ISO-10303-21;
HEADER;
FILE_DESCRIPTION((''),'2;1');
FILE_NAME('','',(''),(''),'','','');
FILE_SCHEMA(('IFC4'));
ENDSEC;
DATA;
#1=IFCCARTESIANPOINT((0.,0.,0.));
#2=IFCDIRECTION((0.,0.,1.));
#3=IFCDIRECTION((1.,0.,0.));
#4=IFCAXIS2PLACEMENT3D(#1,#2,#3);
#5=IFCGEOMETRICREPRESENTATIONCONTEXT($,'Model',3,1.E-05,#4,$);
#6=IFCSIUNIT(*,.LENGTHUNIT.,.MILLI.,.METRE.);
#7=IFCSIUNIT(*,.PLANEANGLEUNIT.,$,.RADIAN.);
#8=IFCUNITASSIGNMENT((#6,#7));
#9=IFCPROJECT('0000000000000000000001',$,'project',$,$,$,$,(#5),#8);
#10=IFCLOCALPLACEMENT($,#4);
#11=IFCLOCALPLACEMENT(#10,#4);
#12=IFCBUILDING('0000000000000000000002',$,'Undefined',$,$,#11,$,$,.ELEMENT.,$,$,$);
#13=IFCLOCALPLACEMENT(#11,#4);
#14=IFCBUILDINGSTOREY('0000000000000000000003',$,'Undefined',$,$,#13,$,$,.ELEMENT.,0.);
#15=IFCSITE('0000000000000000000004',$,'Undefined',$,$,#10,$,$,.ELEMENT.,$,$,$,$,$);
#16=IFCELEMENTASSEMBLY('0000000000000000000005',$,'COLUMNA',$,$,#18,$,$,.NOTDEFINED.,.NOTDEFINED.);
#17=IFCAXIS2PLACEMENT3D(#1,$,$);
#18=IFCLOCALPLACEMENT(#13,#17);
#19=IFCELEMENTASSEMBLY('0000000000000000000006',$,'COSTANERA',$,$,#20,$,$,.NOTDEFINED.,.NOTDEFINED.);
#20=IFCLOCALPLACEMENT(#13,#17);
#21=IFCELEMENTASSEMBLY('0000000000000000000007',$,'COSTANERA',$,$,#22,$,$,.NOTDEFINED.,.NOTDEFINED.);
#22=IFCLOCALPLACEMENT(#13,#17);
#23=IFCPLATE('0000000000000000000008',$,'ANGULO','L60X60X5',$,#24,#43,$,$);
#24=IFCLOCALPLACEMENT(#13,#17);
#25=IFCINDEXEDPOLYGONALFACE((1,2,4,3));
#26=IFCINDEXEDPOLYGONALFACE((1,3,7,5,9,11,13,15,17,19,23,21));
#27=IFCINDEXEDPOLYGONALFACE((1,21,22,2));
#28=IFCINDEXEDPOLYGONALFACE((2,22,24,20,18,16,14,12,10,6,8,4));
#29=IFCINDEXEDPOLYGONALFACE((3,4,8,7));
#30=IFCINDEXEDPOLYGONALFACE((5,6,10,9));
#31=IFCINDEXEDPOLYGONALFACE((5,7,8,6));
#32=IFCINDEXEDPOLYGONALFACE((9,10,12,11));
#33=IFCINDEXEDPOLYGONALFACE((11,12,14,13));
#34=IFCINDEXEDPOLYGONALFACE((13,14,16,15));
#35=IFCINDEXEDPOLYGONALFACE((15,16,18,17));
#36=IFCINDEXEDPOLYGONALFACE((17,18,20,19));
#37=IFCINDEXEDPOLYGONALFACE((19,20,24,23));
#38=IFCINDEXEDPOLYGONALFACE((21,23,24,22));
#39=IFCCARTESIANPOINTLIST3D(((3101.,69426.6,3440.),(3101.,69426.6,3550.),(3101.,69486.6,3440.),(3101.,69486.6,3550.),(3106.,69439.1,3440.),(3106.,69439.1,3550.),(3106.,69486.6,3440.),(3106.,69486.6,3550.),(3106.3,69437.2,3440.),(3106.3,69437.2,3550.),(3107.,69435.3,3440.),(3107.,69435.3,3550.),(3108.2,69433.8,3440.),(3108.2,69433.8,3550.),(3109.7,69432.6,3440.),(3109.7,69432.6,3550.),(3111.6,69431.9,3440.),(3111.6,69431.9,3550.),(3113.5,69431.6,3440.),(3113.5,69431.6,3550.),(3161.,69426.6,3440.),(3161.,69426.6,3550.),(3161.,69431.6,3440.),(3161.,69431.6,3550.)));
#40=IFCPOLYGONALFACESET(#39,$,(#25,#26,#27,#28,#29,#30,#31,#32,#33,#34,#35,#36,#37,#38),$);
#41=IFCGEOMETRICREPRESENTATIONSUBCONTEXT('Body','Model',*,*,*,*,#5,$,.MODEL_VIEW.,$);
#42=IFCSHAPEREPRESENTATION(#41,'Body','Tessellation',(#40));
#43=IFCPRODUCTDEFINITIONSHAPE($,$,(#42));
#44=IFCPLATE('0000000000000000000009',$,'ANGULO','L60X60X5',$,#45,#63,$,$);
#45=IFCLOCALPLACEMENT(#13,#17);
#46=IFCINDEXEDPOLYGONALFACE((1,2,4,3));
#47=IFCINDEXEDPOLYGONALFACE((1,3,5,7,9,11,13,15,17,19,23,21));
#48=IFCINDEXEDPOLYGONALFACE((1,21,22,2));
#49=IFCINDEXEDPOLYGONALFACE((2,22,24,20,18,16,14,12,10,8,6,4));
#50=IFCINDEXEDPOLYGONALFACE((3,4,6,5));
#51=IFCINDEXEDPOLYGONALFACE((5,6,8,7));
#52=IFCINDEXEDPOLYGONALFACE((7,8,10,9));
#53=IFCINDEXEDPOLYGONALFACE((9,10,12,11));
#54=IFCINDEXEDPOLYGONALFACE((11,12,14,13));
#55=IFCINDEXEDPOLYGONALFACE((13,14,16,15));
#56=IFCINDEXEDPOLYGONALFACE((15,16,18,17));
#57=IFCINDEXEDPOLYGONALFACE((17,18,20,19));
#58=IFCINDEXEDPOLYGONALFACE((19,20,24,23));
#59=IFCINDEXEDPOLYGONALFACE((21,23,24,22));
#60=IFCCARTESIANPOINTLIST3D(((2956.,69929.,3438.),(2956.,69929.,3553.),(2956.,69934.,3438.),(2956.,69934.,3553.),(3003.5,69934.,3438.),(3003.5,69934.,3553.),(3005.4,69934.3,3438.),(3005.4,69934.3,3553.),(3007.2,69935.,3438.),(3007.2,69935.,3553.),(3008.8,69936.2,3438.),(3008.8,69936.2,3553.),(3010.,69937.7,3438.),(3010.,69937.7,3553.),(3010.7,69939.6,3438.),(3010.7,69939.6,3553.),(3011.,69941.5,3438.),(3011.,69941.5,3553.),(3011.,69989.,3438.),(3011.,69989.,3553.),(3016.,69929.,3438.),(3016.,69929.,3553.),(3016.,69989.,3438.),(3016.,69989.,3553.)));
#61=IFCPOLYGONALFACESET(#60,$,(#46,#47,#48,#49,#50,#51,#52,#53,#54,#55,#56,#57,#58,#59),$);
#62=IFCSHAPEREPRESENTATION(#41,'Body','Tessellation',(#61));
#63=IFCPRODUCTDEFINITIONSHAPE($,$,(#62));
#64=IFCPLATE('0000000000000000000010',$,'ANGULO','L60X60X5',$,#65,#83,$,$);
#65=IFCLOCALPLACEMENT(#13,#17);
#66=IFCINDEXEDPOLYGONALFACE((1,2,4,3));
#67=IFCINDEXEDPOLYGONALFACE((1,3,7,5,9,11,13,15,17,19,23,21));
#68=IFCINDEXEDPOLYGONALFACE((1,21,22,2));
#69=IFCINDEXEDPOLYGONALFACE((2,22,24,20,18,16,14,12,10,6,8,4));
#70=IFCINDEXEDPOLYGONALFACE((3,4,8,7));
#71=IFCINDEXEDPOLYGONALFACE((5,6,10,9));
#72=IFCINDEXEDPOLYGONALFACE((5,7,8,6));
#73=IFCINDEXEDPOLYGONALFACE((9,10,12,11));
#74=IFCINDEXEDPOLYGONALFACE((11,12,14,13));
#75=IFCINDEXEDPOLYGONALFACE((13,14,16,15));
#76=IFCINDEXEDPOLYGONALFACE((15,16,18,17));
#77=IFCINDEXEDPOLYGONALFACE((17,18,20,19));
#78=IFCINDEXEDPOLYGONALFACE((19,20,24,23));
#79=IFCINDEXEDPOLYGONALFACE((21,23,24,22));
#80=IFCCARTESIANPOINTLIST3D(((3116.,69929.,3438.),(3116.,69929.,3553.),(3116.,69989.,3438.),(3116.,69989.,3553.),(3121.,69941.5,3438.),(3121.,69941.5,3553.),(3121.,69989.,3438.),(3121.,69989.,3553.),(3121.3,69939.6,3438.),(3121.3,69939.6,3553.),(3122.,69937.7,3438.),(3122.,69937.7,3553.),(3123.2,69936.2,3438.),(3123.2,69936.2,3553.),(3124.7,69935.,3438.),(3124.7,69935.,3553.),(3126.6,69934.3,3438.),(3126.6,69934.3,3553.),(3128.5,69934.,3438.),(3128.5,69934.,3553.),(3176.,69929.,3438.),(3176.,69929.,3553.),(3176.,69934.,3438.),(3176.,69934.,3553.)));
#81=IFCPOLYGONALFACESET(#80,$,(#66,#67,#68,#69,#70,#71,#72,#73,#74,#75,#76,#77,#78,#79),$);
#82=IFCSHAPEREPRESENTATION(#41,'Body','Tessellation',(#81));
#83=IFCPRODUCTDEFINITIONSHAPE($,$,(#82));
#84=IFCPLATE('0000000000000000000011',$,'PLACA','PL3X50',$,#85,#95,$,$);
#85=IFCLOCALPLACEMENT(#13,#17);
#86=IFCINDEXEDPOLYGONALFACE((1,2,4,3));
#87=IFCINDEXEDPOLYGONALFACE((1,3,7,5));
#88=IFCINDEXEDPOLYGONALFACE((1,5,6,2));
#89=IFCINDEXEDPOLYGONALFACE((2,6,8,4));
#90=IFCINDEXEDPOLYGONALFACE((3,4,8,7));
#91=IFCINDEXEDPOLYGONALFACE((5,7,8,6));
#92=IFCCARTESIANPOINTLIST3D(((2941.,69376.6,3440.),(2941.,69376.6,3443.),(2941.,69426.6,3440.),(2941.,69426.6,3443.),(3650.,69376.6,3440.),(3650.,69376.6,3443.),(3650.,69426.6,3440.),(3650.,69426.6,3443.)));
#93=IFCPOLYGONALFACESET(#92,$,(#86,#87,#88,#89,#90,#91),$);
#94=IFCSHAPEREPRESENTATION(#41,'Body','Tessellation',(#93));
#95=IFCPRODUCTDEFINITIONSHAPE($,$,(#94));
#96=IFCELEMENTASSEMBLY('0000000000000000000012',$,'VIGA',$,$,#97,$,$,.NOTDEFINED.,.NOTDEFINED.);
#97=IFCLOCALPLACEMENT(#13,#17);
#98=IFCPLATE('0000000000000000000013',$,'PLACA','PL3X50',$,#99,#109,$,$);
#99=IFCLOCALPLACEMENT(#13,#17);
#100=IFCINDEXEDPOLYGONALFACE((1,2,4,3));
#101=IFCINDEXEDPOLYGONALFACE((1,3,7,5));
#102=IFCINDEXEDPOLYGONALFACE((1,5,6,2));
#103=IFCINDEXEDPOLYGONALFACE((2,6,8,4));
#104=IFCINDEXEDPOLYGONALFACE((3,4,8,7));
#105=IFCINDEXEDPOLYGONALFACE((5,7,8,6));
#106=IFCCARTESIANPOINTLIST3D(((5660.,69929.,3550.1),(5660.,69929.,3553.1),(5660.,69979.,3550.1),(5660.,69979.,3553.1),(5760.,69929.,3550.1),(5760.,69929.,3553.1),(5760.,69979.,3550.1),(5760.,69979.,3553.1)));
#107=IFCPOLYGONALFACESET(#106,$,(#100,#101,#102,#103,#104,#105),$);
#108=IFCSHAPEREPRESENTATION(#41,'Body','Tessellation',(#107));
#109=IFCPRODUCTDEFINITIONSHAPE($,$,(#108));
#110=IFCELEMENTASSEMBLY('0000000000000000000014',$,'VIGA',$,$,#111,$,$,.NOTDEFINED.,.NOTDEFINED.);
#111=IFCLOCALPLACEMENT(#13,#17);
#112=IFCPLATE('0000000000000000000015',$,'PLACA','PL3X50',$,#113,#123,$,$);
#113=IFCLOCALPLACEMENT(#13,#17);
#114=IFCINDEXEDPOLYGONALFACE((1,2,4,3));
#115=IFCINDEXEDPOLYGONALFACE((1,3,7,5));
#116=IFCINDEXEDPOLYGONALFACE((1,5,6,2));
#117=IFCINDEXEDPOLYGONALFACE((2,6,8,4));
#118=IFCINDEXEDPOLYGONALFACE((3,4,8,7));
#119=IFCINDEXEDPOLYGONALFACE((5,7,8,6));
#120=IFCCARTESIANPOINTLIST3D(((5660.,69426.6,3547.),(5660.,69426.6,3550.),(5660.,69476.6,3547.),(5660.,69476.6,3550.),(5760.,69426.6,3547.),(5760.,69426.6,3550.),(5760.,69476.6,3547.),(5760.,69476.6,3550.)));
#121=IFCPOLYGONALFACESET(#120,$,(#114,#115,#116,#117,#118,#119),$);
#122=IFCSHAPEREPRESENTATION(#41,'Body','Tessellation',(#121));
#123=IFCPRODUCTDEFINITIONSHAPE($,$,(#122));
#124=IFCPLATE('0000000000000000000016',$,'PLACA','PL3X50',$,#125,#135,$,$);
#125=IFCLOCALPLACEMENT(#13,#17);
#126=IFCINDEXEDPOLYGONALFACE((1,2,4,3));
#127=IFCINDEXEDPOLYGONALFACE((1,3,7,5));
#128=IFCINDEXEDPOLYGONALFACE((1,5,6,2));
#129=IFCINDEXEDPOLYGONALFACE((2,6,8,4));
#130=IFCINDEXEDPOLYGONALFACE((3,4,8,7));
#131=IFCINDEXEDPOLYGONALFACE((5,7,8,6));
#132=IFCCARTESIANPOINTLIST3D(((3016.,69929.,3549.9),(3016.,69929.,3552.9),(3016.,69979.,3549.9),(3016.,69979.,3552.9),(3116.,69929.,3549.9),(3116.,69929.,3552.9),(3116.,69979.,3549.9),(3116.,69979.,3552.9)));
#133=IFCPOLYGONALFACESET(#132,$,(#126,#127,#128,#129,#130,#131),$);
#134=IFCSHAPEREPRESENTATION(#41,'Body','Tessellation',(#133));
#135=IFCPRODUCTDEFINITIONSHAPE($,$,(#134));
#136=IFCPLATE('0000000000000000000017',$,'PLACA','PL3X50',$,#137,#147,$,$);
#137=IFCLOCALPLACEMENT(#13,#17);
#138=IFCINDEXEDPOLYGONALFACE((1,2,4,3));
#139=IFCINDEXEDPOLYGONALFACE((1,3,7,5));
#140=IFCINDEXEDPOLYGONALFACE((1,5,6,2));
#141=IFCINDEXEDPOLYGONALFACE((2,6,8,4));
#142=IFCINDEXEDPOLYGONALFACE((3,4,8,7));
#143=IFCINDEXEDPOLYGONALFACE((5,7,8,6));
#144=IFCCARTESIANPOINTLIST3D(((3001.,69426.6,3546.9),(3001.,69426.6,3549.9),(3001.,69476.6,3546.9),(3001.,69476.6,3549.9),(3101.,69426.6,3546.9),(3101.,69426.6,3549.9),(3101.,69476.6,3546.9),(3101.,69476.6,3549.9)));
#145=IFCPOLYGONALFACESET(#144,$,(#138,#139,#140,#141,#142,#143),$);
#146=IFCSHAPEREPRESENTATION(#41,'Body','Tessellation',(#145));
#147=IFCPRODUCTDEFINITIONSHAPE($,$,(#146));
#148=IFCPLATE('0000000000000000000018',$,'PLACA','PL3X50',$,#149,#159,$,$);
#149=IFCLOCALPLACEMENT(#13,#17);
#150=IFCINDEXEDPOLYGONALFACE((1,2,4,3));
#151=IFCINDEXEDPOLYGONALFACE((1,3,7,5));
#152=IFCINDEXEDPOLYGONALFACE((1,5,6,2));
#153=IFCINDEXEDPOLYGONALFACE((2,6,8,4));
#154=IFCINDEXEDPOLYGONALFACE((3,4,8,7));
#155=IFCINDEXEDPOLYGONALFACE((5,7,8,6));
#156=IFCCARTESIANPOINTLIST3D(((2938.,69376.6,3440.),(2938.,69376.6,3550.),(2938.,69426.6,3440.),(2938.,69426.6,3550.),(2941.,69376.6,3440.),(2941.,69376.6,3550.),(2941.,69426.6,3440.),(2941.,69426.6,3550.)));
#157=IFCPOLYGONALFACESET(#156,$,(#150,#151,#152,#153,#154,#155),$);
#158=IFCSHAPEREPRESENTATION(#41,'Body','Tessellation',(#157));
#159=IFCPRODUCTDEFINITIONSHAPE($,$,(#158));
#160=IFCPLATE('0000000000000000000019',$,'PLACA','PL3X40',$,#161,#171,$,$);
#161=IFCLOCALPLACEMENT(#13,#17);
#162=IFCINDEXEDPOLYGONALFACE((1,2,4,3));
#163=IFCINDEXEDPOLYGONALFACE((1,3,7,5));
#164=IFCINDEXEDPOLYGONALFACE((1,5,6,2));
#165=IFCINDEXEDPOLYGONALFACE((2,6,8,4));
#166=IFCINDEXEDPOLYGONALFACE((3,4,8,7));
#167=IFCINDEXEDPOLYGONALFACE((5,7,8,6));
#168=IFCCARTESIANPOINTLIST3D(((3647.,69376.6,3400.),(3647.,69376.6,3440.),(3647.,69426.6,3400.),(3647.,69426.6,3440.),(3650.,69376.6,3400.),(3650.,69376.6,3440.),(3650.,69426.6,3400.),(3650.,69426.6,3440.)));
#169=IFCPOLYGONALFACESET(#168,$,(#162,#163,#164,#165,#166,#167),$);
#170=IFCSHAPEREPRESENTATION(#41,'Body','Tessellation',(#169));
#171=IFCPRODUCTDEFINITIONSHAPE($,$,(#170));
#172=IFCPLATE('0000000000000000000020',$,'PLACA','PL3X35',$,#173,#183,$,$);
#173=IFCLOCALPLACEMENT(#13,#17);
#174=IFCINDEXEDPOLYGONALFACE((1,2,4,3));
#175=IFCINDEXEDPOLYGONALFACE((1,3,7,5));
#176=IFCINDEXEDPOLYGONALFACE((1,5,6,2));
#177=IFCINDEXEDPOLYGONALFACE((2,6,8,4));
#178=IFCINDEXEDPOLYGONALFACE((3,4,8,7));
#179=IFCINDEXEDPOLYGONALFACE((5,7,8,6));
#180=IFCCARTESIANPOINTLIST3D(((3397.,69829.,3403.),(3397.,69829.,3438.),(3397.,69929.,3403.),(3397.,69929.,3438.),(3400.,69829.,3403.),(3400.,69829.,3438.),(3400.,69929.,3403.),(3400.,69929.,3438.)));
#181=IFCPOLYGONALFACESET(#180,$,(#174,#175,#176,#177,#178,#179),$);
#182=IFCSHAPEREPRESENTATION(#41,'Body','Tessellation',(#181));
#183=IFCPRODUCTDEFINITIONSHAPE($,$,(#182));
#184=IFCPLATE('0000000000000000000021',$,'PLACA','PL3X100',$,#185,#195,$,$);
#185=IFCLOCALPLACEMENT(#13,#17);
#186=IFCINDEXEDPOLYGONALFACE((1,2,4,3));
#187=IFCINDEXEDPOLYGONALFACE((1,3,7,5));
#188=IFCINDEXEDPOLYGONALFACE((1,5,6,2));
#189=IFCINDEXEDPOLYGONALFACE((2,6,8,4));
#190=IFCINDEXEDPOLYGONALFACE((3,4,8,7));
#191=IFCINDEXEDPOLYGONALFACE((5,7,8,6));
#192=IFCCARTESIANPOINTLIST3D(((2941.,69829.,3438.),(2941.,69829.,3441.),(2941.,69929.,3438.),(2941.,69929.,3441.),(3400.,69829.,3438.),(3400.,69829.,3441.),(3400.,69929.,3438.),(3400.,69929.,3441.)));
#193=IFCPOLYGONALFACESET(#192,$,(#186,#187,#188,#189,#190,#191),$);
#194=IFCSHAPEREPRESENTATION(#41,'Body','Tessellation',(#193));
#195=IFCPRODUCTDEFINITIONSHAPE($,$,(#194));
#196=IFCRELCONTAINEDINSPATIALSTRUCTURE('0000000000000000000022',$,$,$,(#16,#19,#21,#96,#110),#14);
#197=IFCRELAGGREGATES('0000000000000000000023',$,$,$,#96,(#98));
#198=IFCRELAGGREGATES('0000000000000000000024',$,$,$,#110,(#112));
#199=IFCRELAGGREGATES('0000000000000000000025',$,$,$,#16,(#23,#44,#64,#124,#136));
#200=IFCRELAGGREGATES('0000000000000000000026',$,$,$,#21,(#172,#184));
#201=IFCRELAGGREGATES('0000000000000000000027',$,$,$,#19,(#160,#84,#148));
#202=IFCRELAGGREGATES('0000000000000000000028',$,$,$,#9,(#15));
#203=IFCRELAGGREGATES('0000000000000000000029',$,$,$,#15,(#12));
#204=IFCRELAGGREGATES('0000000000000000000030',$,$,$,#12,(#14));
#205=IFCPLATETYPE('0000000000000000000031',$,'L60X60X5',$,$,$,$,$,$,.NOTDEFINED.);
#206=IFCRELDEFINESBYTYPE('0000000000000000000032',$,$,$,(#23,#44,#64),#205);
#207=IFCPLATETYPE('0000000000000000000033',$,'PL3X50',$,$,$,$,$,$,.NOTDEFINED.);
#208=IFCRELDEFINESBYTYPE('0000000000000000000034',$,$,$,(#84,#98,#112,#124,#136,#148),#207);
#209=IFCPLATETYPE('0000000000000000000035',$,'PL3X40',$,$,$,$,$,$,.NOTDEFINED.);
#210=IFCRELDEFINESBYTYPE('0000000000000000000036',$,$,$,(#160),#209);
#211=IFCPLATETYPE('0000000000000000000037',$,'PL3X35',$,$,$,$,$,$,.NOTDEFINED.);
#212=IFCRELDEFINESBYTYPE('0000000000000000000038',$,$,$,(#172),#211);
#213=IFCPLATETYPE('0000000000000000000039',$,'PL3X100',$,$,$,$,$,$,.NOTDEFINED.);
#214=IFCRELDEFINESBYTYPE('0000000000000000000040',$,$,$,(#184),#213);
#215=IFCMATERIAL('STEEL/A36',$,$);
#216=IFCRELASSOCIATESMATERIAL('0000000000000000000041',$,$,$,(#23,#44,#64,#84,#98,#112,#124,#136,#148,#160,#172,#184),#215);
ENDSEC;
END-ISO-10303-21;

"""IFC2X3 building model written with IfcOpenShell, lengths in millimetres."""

from ifc_helpers import new_model, si_unit, frame, origin_with_axes, origin_2d_with_axis, place, context, subcontext, project, spatial, polyline, l_section, outline, extrude, material, type_object, element, aggregate, save


model = new_model("IFC2X3")

# Units and contexts
model_context = context("Model", 3, precision=1e-05, world=origin_with_axes())
body_context = subcontext(model_context, "Body", "Model", "MODEL_VIEW")
ifc_project = project(units=[si_unit("LENGTHUNIT", "METRE", prefix="MILLI"), si_unit("PLANEANGLEUNIT", "RADIAN")], contexts=[model_context])

# Site, building, storey
site_placement = place(None, origin_with_axes())
site = spatial("IfcSite", under=ifc_project, at=site_placement, Name="Undefined", CompositionType="ELEMENT")
building_placement = place(site_placement, origin_with_axes())
building = spatial("IfcBuilding", under=site, at=building_placement, Name="Undefined", CompositionType="ELEMENT")
storey_placement = place(building_placement, origin_with_axes())
storey = spatial("IfcBuildingStorey", under=building, at=storey_placement, Name="Undefined", CompositionType="ELEMENT", Elevation=0.0)

# Element assembly
assembly_1_placement = place(storey_placement, origin_with_axes())
assembly_1 = element("IfcElementAssembly", 1, at=assembly_1_placement, inside=storey, Name="COLUMNA", AssemblyPlace="NOTDEFINED", PredefinedType="NOTDEFINED")
ifc_material_1 = material(Name="STEEL/A36")

# Element assemblies
assembly_2_placement = place(storey_placement, origin_with_axes())
assembly_2 = element("IfcElementAssembly", 2, at=assembly_2_placement, inside=storey, Name="COSTANERA", AssemblyPlace="NOTDEFINED", PredefinedType="NOTDEFINED")
assembly_3_placement = place(storey_placement, origin_with_axes())
assembly_3 = element("IfcElementAssembly", 3, at=assembly_3_placement, inside=storey, Name="COSTANERA", AssemblyPlace="NOTDEFINED", PredefinedType="NOTDEFINED")

# Plates
plate_type_1 = type_object("IfcPlateType", Name="L60X60X5", PredefinedType="NOTDEFINED")
plate_1_placement = place(assembly_1_placement, frame((3131.0, 69456.6, 3550.0), z_axis=(0.0, 1.0, 0.0), x_axis=(0.0, 0.0, -1.0)))
plate_1 = element("IfcPlate", 4, at=plate_1_placement, type_object=plate_type_1, material=ifc_material_1, Name="ANGULO", Description="L60X60X5", context=body_context, shape_type="SweptSolid", body=[
    extrude(l_section(Depth=60.0, Width=60.0, Thickness=5.0, FilletRadius=7.5, at=origin_2d_with_axis()), frame((110.0, 0.0, 0.0), z_axis=(-1.0, 0.0, 0.0), x_axis=(0.0, -1.0, 0.0)), (0.0, 0.0, 1.0), 110.0),
])
plate_2_placement = place(assembly_1_placement, frame((2986.0, 69959.0, 3438.0), z_axis=(0.0, 1.0, 0.0), x_axis=(0.0, 0.0, 1.0)))
plate_2 = element("IfcPlate", 5, at=plate_2_placement, type_object=plate_type_1, material=ifc_material_1, Name="ANGULO", Description="L60X60X5", context=body_context, shape_type="SweptSolid", body=[
    extrude(l_section(Depth=60.0, Width=60.0, Thickness=5.0, FilletRadius=7.5, at=origin_2d_with_axis()), frame((115.0, 0.0, 0.0), z_axis=(-1.0, 0.0, 0.0), x_axis=(0.0, -1.0, 0.0)), (0.0, 0.0, 1.0), 115.0),
])
plate_3_placement = place(assembly_1_placement, frame((3146.0, 69959.0, 3553.0), z_axis=(0.0, 1.0, 0.0), x_axis=(0.0, 0.0, -1.0)))
plate_3 = element("IfcPlate", 6, at=plate_3_placement, type_object=plate_type_1, material=ifc_material_1, Name="ANGULO", Description="L60X60X5", context=body_context, shape_type="SweptSolid", body=[
    extrude(l_section(Depth=60.0, Width=60.0, Thickness=5.0, FilletRadius=7.5, at=origin_2d_with_axis()), frame((115.0, 0.0, 0.0), z_axis=(-1.0, 0.0, 0.0), x_axis=(0.0, -1.0, 0.0)), (0.0, 0.0, 1.0), 115.0),
])
plate_type_2 = type_object("IfcPlateType", Name="PL3X50", PredefinedType="NOTDEFINED")
plate_4_placement = place(assembly_2_placement, frame((2941.0, 69376.6, 3441.5), z_axis=(0.0, 0.0, 1.0), x_axis=(1.0, 0.0, 0.0)))
plate_4 = element("IfcPlate", 7, at=plate_4_placement, type_object=plate_type_2, material=ifc_material_1, Name="PLACA", Description="PL3X50", context=body_context, shape_type="SweptSolid", body=[
    extrude(outline(polyline([(0.0, 0.0), (709.0, 0.0), (709.0, 50.0), (0.0, 50.0), (0.0, 0.0)])), frame((0.0, 0.0, -1.5), z_axis=(0.0, 0.0, 1.0), x_axis=(1.0, 0.0, 0.0)), (0.0, 0.0, 1.0), 3.0),
])

# Element assemblies, plates
assembly_4_placement = place(storey_placement, origin_with_axes())
assembly_4 = element("IfcElementAssembly", 8, at=assembly_4_placement, inside=storey, Name="VIGA", AssemblyPlace="NOTDEFINED", PredefinedType="NOTDEFINED")
plate_5_placement = place(assembly_4_placement, frame((5660.0, 69929.0, 3551.6), z_axis=(0.0, 0.0, -1.0), x_axis=(0.0, 1.0, 0.0)))
plate_5 = element("IfcPlate", 9, at=plate_5_placement, type_object=plate_type_2, material=ifc_material_1, Name="PLACA", Description="PL3X50", context=body_context, shape_type="SweptSolid", body=[
    extrude(outline(polyline([(0.0, 0.0), (50.0, 0.0), (50.0, 100.0), (0.0, 100.0), (0.0, 0.0)])), frame((0.0, 0.0, -1.5), z_axis=(0.0, 0.0, 1.0), x_axis=(1.0, 0.0, 0.0)), (0.0, 0.0, 1.0), 3.0),
])
aggregate(assembly_4, [plate_5])
assembly_5_placement = place(storey_placement, origin_with_axes())
assembly_5 = element("IfcElementAssembly", 10, at=assembly_5_placement, inside=storey, Name="VIGA", AssemblyPlace="NOTDEFINED", PredefinedType="NOTDEFINED")
plate_6_placement = place(assembly_5_placement, frame((5660.0, 69426.6, 3548.5), z_axis=(0.0, 0.0, -1.0), x_axis=(0.0, 1.0, 0.0)))
plate_6 = element("IfcPlate", 11, at=plate_6_placement, type_object=plate_type_2, material=ifc_material_1, Name="PLACA", Description="PL3X50", context=body_context, shape_type="SweptSolid", body=[
    extrude(outline(polyline([(0.0, 0.0), (50.0, 0.0), (50.0, 100.0), (0.0, 100.0), (0.0, 0.0)])), frame((0.0, 0.0, -1.5), z_axis=(0.0, 0.0, 1.0), x_axis=(1.0, 0.0, 0.0)), (0.0, 0.0, 1.0), 3.0),
])
aggregate(assembly_5, [plate_6])

# Plates
plate_7_placement = place(assembly_1_placement, frame((3016.0, 69929.0, 3551.4), z_axis=(0.0, 0.0, -1.0), x_axis=(0.0, 1.0, 0.0)))
plate_7 = element("IfcPlate", 12, at=plate_7_placement, type_object=plate_type_2, material=ifc_material_1, Name="PLACA", Description="PL3X50", context=body_context, shape_type="SweptSolid", body=[
    extrude(outline(polyline([(0.0, 0.0), (50.0, 0.0), (50.0, 100.0), (0.0, 100.0), (0.0, 0.0)])), frame((0.0, 0.0, -1.5), z_axis=(0.0, 0.0, 1.0), x_axis=(1.0, 0.0, 0.0)), (0.0, 0.0, 1.0), 3.0),
])
plate_8_placement = place(assembly_1_placement, frame((3001.0, 69426.6, 3548.4), z_axis=(0.0, 0.0, -1.0), x_axis=(0.0, 1.0, 0.0)))
plate_8 = element("IfcPlate", 13, at=plate_8_placement, type_object=plate_type_2, material=ifc_material_1, Name="PLACA", Description="PL3X50", context=body_context, shape_type="SweptSolid", body=[
    extrude(outline(polyline([(0.0, 0.0), (50.0, 0.0), (50.0, 100.0), (0.0, 100.0), (0.0, 0.0)])), frame((0.0, 0.0, -1.5), z_axis=(0.0, 0.0, 1.0), x_axis=(1.0, 0.0, 0.0)), (0.0, 0.0, 1.0), 3.0),
])
aggregate(assembly_1, [plate_1, plate_2, plate_3, plate_7, plate_8])
plate_9_placement = place(assembly_2_placement, frame((2939.5, 69376.6, 3440.0), z_axis=(1.0, 0.0, 0.0), x_axis=(0.0, 1.0, 0.0)))
plate_9 = element("IfcPlate", 14, at=plate_9_placement, type_object=plate_type_2, material=ifc_material_1, Name="PLACA", Description="PL3X50", context=body_context, shape_type="SweptSolid", body=[
    extrude(outline(polyline([(0.0, 0.0), (50.0, 0.0), (50.0, 110.0), (0.0, 110.0), (0.0, 0.0)])), frame((0.0, 0.0, -1.5), z_axis=(0.0, 0.0, 1.0), x_axis=(1.0, 0.0, 0.0)), (0.0, 0.0, 1.0), 3.0),
])
plate_type_3 = type_object("IfcPlateType", Name="PL3X40", PredefinedType="NOTDEFINED")
plate_10_placement = place(assembly_2_placement, frame((3648.5, 69376.6, 3440.0), z_axis=(1.0, 0.0, 0.0), x_axis=(0.0, 0.0, -1.0)))
plate_10 = element("IfcPlate", 15, at=plate_10_placement, type_object=plate_type_3, material=ifc_material_1, Name="PLACA", Description="PL3X40", context=body_context, shape_type="SweptSolid", body=[
    extrude(outline(polyline([(0.0, 0.0), (40.0, 0.0), (40.0, 50.0), (0.0, 50.0), (0.0, 0.0)])), frame((0.0, 0.0, -1.5), z_axis=(0.0, 0.0, 1.0), x_axis=(1.0, 0.0, 0.0)), (0.0, 0.0, 1.0), 3.0),
])
plate_type_4 = type_object("IfcPlateType", Name="PL3X35", PredefinedType="NOTDEFINED")
plate_11_placement = place(assembly_3_placement, frame((3398.5, 69829.0, 3438.0), z_axis=(1.0, 0.0, 0.0), x_axis=(0.0, 0.0, -1.0)))
plate_11 = element("IfcPlate", 16, at=plate_11_placement, type_object=plate_type_4, material=ifc_material_1, Name="PLACA", Description="PL3X35", context=body_context, shape_type="SweptSolid", body=[
    extrude(outline(polyline([(0.0, 0.0), (35.0, 0.0), (35.0, 100.0), (0.0, 100.0), (0.0, 0.0)])), frame((0.0, 0.0, -1.5), z_axis=(0.0, 0.0, 1.0), x_axis=(1.0, 0.0, 0.0)), (0.0, 0.0, 1.0), 3.0),
])
plate_type_5 = type_object("IfcPlateType", Name="PL3X100", PredefinedType="NOTDEFINED")
plate_12_placement = place(assembly_3_placement, frame((2941.0, 69829.0, 3439.5), z_axis=(0.0, 0.0, 1.0), x_axis=(1.0, 0.0, 0.0)))
plate_12 = element("IfcPlate", 17, at=plate_12_placement, type_object=plate_type_5, material=ifc_material_1, Name="PLACA", Description="PL3X100", context=body_context, shape_type="SweptSolid", body=[
    extrude(outline(polyline([(0.0, 0.0), (459.0, 0.0), (459.0, 100.0), (0.0, 100.0), (0.0, 0.0)])), frame((0.0, 0.0, -1.5), z_axis=(0.0, 0.0, 1.0), x_axis=(1.0, 0.0, 0.0)), (0.0, 0.0, 1.0), 3.0),
])

aggregate(assembly_3, [plate_11, plate_12])
aggregate(assembly_2, [plate_10, plate_4, plate_9])

save(model, "model.ifc")
